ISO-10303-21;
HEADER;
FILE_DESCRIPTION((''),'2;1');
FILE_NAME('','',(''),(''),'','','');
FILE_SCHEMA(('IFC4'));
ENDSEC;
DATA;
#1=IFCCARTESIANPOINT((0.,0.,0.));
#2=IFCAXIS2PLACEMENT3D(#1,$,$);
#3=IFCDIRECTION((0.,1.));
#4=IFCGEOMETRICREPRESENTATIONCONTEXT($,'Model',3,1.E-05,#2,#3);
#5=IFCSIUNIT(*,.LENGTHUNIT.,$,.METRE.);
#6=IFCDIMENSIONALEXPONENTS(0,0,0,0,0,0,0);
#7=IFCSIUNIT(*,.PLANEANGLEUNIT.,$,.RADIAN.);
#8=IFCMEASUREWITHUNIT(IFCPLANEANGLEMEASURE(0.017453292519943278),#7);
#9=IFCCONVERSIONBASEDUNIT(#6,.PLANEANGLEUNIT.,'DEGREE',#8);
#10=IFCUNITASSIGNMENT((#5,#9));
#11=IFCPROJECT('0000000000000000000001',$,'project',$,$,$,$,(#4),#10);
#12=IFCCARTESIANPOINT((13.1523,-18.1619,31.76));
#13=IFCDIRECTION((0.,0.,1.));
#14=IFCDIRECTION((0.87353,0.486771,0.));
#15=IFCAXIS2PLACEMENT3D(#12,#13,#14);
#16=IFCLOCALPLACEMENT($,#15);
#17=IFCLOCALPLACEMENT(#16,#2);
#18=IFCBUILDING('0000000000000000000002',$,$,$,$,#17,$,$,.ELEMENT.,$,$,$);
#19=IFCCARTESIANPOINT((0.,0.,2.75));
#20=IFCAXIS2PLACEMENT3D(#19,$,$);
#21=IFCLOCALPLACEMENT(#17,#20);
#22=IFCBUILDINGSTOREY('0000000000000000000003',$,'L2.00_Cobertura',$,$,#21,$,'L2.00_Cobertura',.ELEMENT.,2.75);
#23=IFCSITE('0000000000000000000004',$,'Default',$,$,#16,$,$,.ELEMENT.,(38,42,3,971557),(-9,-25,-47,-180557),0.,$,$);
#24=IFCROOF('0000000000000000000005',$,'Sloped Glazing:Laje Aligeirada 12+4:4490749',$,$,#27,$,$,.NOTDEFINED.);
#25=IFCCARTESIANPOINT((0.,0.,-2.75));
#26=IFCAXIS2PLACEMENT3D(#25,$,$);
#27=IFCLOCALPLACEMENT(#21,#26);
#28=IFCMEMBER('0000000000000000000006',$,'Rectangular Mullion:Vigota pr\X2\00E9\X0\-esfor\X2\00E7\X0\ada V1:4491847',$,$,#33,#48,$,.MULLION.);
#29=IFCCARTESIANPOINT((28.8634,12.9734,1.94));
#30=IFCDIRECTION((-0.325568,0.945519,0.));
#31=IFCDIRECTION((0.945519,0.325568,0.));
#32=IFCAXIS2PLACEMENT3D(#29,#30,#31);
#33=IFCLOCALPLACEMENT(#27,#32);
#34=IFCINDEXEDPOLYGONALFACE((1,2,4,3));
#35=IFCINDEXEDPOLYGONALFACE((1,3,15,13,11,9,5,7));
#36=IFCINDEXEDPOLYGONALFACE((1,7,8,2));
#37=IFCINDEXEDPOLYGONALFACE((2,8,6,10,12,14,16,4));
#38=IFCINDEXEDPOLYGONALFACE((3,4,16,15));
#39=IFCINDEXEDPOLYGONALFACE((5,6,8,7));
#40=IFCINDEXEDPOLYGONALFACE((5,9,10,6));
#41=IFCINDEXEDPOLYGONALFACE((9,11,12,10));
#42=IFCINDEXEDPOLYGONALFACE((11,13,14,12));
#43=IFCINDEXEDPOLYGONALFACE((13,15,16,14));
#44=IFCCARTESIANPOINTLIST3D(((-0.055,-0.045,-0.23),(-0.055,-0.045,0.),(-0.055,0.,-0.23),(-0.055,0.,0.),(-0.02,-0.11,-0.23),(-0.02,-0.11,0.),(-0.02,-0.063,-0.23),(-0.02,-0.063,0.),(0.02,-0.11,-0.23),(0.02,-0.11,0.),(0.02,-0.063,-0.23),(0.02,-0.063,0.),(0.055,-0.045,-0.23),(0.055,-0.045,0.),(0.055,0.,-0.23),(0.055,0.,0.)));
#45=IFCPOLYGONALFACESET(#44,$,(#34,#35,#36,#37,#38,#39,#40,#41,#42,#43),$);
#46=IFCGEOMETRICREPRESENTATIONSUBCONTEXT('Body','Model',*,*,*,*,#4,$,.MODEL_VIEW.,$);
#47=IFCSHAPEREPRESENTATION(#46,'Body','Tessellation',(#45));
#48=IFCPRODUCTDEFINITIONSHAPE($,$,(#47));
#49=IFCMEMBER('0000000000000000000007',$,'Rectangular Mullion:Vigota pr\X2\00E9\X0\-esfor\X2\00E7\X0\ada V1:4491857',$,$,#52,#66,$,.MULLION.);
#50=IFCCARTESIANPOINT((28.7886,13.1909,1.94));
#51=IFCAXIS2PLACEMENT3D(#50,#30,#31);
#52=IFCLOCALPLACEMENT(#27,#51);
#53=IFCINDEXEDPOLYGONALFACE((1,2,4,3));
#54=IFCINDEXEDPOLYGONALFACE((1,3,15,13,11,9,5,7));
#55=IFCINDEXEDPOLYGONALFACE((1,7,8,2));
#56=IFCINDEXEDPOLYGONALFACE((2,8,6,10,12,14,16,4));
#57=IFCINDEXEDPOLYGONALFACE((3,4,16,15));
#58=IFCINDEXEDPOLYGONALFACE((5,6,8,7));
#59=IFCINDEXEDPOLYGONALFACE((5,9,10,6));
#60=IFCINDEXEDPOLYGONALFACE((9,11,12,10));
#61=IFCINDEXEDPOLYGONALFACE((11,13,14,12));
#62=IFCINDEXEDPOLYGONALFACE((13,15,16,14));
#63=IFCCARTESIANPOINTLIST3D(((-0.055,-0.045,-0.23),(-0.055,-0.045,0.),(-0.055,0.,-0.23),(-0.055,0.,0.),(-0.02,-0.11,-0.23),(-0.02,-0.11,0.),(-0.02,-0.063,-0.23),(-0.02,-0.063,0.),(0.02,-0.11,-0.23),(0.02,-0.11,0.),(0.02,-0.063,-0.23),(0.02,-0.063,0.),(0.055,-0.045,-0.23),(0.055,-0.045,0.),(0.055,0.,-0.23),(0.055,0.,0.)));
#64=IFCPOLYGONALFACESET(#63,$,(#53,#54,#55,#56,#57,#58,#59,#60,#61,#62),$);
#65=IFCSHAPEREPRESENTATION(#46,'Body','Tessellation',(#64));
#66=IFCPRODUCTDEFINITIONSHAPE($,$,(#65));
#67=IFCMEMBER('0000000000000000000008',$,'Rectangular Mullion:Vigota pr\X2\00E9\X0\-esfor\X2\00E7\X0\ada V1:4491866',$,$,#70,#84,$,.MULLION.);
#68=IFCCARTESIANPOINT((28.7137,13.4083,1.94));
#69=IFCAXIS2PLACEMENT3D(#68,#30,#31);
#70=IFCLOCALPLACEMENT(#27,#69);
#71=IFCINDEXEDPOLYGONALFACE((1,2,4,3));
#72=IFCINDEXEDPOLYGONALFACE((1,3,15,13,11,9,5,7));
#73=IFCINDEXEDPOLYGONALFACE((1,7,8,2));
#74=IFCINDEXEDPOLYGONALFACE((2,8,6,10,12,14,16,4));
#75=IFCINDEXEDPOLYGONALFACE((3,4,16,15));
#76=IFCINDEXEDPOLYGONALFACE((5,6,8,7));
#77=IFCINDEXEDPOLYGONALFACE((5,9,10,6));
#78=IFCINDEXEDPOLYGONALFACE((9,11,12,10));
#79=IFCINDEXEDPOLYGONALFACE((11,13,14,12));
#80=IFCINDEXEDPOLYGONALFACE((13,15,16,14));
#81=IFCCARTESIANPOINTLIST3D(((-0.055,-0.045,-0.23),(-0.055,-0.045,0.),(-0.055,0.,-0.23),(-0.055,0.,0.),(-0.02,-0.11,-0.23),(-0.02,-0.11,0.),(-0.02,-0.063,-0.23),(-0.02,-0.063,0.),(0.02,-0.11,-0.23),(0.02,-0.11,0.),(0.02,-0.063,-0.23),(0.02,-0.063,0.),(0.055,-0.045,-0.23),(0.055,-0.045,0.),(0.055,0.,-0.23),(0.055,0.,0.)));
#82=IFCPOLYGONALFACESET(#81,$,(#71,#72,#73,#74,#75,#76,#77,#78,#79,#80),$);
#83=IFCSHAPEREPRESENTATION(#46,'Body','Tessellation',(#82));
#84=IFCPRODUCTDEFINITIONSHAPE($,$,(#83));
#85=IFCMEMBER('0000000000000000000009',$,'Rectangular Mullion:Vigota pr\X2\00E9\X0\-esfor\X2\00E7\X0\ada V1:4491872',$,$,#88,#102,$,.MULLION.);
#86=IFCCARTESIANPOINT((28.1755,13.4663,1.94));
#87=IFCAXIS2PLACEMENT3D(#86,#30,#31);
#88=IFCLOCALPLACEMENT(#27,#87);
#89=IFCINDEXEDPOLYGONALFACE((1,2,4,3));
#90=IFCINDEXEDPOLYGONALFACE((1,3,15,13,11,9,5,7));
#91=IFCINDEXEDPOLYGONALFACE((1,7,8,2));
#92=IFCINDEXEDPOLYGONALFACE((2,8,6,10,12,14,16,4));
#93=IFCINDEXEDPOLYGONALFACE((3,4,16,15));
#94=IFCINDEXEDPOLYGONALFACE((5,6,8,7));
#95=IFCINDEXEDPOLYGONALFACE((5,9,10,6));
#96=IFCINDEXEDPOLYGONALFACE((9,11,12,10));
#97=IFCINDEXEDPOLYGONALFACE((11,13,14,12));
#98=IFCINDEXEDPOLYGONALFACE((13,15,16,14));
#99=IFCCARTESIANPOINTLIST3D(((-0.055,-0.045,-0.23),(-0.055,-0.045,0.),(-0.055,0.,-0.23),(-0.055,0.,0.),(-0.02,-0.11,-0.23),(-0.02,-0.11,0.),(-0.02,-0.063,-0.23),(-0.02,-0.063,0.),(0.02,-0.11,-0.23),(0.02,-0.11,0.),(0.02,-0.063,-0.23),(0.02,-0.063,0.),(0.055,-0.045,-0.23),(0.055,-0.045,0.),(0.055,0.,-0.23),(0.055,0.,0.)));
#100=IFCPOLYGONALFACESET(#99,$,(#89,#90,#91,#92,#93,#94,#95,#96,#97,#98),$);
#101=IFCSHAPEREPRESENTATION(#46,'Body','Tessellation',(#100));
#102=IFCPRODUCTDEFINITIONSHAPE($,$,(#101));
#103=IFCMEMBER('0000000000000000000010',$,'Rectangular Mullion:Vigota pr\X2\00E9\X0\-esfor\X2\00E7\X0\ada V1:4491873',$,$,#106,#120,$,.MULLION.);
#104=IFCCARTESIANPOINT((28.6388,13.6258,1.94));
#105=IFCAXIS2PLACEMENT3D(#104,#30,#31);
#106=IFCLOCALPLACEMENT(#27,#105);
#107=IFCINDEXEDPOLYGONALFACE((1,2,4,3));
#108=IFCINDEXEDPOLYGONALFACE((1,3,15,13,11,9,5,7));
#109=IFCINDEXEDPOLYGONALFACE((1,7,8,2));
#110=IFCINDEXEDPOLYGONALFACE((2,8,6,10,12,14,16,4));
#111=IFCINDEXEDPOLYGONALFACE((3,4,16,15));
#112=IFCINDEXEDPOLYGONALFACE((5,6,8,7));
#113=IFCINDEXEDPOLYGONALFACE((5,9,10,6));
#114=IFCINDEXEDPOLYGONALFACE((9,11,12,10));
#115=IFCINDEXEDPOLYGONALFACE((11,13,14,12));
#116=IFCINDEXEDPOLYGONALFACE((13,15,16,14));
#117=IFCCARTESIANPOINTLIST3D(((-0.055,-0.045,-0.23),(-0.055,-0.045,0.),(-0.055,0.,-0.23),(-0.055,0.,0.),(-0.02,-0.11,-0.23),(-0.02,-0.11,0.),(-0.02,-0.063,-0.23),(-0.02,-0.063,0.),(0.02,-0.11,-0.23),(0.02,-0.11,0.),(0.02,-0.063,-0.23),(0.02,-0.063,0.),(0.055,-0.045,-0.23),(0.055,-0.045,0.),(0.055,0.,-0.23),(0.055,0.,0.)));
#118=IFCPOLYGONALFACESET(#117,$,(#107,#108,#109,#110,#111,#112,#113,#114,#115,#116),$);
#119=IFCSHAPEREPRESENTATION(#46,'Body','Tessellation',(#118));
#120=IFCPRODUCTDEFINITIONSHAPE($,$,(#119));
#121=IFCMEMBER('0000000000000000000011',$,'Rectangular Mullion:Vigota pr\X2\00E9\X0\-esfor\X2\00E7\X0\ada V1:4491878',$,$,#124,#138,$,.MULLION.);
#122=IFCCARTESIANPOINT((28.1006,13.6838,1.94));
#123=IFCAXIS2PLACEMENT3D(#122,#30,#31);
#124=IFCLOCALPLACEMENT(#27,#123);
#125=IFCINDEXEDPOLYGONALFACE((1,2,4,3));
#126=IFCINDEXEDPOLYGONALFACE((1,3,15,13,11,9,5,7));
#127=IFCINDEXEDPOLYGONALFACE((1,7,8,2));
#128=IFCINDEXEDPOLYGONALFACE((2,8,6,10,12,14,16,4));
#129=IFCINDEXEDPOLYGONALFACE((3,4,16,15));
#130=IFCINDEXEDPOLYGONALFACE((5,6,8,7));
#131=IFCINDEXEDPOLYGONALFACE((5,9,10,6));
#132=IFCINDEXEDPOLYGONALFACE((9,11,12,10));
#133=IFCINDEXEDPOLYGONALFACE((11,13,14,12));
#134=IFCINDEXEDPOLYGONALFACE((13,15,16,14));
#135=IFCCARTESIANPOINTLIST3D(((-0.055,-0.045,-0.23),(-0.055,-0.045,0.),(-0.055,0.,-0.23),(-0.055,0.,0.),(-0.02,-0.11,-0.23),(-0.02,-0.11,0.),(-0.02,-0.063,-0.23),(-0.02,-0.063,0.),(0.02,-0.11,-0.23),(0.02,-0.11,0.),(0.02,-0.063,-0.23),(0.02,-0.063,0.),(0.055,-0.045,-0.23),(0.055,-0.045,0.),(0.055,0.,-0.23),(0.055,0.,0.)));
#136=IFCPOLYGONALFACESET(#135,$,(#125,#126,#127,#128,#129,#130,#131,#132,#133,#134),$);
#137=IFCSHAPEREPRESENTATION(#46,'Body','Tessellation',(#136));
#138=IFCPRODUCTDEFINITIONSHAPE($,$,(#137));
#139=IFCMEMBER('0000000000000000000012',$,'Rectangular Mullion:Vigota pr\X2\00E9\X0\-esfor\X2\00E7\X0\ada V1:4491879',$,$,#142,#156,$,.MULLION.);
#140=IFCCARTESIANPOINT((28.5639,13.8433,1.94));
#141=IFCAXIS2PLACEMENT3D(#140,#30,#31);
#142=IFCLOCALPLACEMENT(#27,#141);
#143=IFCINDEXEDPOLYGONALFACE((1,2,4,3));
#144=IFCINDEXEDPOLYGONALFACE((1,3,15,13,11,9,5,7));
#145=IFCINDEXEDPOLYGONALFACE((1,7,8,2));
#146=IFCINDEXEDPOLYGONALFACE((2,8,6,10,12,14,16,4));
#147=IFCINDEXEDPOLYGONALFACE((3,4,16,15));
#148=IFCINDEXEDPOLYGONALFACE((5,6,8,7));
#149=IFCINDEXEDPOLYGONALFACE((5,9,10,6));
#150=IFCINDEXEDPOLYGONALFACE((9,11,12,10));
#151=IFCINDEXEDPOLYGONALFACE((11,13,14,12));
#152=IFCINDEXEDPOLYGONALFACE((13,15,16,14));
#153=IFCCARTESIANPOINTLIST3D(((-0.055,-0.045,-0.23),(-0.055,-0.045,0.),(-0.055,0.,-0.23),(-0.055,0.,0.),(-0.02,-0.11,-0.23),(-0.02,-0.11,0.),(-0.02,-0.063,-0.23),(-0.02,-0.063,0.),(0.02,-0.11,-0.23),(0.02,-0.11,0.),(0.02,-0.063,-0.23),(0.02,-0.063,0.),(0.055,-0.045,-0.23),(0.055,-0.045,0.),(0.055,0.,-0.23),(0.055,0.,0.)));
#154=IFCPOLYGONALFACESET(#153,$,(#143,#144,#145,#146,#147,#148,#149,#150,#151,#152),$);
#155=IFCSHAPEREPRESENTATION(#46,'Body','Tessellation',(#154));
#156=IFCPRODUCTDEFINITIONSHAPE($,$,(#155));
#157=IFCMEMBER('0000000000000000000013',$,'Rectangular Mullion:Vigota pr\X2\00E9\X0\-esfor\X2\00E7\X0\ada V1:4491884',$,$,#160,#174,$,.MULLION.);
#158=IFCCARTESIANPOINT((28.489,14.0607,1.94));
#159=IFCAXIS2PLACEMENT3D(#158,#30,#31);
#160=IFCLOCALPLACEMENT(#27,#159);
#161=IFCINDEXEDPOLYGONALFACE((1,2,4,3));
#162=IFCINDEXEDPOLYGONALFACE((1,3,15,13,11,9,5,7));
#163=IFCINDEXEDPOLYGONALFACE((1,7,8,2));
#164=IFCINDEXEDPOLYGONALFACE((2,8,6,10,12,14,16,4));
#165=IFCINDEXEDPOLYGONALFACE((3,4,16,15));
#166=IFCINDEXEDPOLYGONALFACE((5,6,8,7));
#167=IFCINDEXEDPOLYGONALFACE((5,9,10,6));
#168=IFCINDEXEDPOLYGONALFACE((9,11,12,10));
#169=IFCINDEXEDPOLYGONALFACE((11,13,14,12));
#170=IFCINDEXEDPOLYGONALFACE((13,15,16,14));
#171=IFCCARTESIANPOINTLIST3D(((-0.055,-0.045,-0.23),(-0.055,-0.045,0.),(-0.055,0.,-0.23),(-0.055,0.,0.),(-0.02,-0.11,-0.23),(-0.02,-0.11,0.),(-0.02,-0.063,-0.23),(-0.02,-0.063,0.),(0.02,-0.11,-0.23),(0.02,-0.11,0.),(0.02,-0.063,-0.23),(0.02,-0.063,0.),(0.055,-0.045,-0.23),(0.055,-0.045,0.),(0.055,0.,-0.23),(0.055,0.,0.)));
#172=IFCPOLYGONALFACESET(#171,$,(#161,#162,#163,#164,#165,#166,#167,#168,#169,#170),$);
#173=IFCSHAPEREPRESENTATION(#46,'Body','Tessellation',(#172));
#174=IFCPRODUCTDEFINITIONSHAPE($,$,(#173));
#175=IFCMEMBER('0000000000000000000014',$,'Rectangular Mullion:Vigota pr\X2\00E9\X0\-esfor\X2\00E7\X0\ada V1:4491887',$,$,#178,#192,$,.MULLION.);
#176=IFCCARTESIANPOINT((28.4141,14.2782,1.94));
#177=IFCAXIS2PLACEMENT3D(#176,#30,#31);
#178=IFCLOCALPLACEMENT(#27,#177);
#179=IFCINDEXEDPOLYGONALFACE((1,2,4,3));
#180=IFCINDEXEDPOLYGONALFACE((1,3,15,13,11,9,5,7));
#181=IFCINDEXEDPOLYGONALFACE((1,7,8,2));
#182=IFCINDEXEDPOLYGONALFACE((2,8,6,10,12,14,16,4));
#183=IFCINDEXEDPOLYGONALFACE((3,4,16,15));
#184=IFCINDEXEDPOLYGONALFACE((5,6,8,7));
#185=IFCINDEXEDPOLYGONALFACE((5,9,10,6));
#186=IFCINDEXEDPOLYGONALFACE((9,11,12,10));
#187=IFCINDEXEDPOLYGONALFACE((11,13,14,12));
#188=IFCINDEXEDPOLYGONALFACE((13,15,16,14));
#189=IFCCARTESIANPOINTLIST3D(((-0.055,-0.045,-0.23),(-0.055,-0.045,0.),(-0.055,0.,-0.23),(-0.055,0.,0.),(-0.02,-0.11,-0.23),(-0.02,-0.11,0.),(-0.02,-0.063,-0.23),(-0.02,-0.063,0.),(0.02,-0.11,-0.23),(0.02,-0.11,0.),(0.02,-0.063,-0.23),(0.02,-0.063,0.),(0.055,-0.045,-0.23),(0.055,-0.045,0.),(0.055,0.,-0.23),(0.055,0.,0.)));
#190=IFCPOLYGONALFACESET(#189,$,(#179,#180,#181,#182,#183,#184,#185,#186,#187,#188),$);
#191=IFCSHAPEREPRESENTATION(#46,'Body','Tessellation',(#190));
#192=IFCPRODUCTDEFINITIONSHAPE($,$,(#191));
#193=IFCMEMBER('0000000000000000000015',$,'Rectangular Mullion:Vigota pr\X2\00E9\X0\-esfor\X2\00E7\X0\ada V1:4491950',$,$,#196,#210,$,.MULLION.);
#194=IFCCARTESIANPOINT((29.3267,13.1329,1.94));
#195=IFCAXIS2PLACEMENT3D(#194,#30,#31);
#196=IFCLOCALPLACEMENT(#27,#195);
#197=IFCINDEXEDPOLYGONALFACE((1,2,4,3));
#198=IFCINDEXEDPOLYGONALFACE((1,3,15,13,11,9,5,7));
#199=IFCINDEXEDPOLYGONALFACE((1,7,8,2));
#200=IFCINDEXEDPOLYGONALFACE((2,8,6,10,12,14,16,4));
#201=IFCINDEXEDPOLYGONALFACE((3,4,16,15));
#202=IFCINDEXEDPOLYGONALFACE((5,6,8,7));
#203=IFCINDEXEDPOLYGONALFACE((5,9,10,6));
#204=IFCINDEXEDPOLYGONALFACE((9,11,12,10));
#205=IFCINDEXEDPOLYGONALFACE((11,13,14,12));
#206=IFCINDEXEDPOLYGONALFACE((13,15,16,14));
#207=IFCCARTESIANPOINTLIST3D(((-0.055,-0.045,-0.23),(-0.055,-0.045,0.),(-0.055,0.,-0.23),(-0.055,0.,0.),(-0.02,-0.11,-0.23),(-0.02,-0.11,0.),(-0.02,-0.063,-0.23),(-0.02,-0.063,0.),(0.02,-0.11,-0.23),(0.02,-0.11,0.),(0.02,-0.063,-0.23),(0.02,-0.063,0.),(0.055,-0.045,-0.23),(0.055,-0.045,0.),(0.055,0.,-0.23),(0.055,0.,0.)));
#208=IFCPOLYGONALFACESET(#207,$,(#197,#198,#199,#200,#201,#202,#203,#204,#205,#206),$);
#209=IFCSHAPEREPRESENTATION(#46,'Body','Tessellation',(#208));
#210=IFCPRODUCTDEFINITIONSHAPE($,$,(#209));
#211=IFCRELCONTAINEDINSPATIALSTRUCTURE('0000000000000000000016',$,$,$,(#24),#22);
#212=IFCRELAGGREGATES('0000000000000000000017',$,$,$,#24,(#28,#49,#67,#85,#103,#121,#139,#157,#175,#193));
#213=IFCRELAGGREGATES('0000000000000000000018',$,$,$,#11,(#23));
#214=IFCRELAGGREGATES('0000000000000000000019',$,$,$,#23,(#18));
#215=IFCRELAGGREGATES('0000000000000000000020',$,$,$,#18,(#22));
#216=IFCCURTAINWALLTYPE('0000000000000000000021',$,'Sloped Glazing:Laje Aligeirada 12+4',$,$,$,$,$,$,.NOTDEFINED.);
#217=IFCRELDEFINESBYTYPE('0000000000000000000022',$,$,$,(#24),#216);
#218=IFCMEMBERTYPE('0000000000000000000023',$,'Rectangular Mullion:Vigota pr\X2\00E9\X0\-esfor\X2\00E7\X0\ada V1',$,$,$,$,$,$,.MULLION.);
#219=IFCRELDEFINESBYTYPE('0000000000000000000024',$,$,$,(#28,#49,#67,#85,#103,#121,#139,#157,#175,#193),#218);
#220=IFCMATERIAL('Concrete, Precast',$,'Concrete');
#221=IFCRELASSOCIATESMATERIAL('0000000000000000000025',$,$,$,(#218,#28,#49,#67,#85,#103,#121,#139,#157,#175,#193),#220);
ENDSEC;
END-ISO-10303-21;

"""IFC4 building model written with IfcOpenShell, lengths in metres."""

from ifc_helpers import new_model, entity, si_unit, converted_unit, direction, frame, origin, place, context, subcontext, project, spatial, indexed_curve, outline, extrude, source, transform, mapped, material, type_object, type_shapes, element, aggregate, save


model = new_model("IFC4")

# Units and contexts
model_context = context("Model", 3, precision=1e-05, world=origin(), true_north=direction((0.0, 1.0)))
body_context = subcontext(model_context, "Body", "Model", "MODEL_VIEW")
ifc_project = project(units=[si_unit("LENGTHUNIT", "METRE"), converted_unit("PLANEANGLEUNIT", "DEGREE", entity("IfcPlaneAngleMeasure", 0.017453292519943278), si_unit("PLANEANGLEUNIT", "RADIAN"), dimensions=[0, 0, 0, 0, 0, 0, 0])], contexts=[model_context])

# Site, building, storey
site_placement = place(None, frame((13.1523, -18.1619, 31.76), z_axis=(0.0, 0.0, 1.0), x_axis=(0.87353, 0.486771, 0.0)))
site = spatial("IfcSite", under=ifc_project, at=site_placement, Name="Default", CompositionType="ELEMENT", RefLatitude=(38, 42, 3, 971557), RefLongitude=(-9, -25, -47, -180557), RefElevation=0.0)
building_placement = place(site_placement, origin())
building = spatial("IfcBuilding", under=site, at=building_placement, CompositionType="ELEMENT")
storey_placement = place(building_placement, frame((0.0, 0.0, 2.75)))
storey = spatial("IfcBuildingStorey", under=building, at=storey_placement, Name="L2.00_Cobertura", LongName="L2.00_Cobertura", CompositionType="ELEMENT", Elevation=2.75)

# Roof, members
curtain_wall_type = type_object("IfcCurtainWallType", Name="Sloped Glazing:Laje Aligeirada 12+4", PredefinedType="NOTDEFINED")
roof_placement = place(storey_placement, frame((0.0, 0.0, -2.75)))
roof = element("IfcRoof", 1, at=roof_placement, inside=storey, type_object=curtain_wall_type, Name="Sloped Glazing:Laje Aligeirada 12+4:4490749", PredefinedType="NOTDEFINED")
ifc_material_1 = material(Name="Concrete, Precast", Category="Concrete")
member_type_1 = type_object("IfcMemberType", Name="Rectangular Mullion:Vigota pré-esforçada V1", PredefinedType="MULLION", material=ifc_material_1)
shared_shape_1 = source(origin(), body_context, "Body", "SweptSolid", [
    extrude(outline(indexed_curve([(-0.055, -0.0545), (0.055, -0.0545), (0.055, -0.0095), (0.02, 0.0085), (0.02, 0.0555), (-0.02, 0.0555), (-0.02, 0.0085), (-0.055, -0.0095), (-0.055, -0.0545)], self_intersect=False)), frame((0.0, -0.0545, -0.23), z_axis=(0.0, 0.0, 1.0), x_axis=(-1.0, 0.0, 0.0)), (0.0, 0.0, 1.0), 0.23),
])
type_shapes(member_type_1, [shared_shape_1])
member_1_placement = place(roof_placement, frame((28.8634, 12.9734, 1.94), z_axis=(-0.325568, 0.945519, 0.0), x_axis=(0.945519, 0.325568, 0.0)))
member_1 = element("IfcMember", 2, at=member_1_placement, type_object=member_type_1, material=ifc_material_1, Name="Rectangular Mullion:Vigota pré-esforçada V1:4491847", PredefinedType="MULLION", context=body_context, shape_type="MappedRepresentation", body=[
    mapped(shared_shape_1, transform((0.0, 0.0, 0.0), scale=1.0)),
])
member_2_placement = place(roof_placement, frame((28.7886, 13.1909, 1.94), z_axis=(-0.325568, 0.945519, 0.0), x_axis=(0.945519, 0.325568, 0.0)))
member_2 = element("IfcMember", 3, at=member_2_placement, type_object=member_type_1, material=ifc_material_1, Name="Rectangular Mullion:Vigota pré-esforçada V1:4491857", PredefinedType="MULLION", context=body_context, shape_type="MappedRepresentation", body=[
    mapped(shared_shape_1, transform((0.0, 0.0, 0.0), scale=1.0)),
])
member_3_placement = place(roof_placement, frame((28.7137, 13.4083, 1.94), z_axis=(-0.325568, 0.945519, 0.0), x_axis=(0.945519, 0.325568, 0.0)))
member_3 = element("IfcMember", 4, at=member_3_placement, type_object=member_type_1, material=ifc_material_1, Name="Rectangular Mullion:Vigota pré-esforçada V1:4491866", PredefinedType="MULLION", context=body_context, shape_type="MappedRepresentation", body=[
    mapped(shared_shape_1, transform((0.0, 0.0, 0.0), scale=1.0)),
])
member_4_placement = place(roof_placement, frame((28.1755, 13.4663, 1.94), z_axis=(-0.325568, 0.945519, 0.0), x_axis=(0.945519, 0.325568, 0.0)))
member_4 = element("IfcMember", 5, at=member_4_placement, type_object=member_type_1, material=ifc_material_1, Name="Rectangular Mullion:Vigota pré-esforçada V1:4491872", PredefinedType="MULLION", context=body_context, shape_type="MappedRepresentation", body=[
    mapped(shared_shape_1, transform((0.0, 0.0, 0.0), scale=1.0)),
])
member_5_placement = place(roof_placement, frame((28.6388, 13.6258, 1.94), z_axis=(-0.325568, 0.945519, 0.0), x_axis=(0.945519, 0.325568, 0.0)))
member_5 = element("IfcMember", 6, at=member_5_placement, type_object=member_type_1, material=ifc_material_1, Name="Rectangular Mullion:Vigota pré-esforçada V1:4491873", PredefinedType="MULLION", context=body_context, shape_type="MappedRepresentation", body=[
    mapped(shared_shape_1, transform((0.0, 0.0, 0.0), scale=1.0)),
])
member_6_placement = place(roof_placement, frame((28.1006, 13.6838, 1.94), z_axis=(-0.325568, 0.945519, 0.0), x_axis=(0.945519, 0.325568, 0.0)))
member_6 = element("IfcMember", 7, at=member_6_placement, type_object=member_type_1, material=ifc_material_1, Name="Rectangular Mullion:Vigota pré-esforçada V1:4491878", PredefinedType="MULLION", context=body_context, shape_type="MappedRepresentation", body=[
    mapped(shared_shape_1, transform((0.0, 0.0, 0.0), scale=1.0)),
])
member_7_placement = place(roof_placement, frame((28.5639, 13.8433, 1.94), z_axis=(-0.325568, 0.945519, 0.0), x_axis=(0.945519, 0.325568, 0.0)))
member_7 = element("IfcMember", 8, at=member_7_placement, type_object=member_type_1, material=ifc_material_1, Name="Rectangular Mullion:Vigota pré-esforçada V1:4491879", PredefinedType="MULLION", context=body_context, shape_type="MappedRepresentation", body=[
    mapped(shared_shape_1, transform((0.0, 0.0, 0.0), scale=1.0)),
])
member_8_placement = place(roof_placement, frame((28.489, 14.0607, 1.94), z_axis=(-0.325568, 0.945519, 0.0), x_axis=(0.945519, 0.325568, 0.0)))
member_8 = element("IfcMember", 9, at=member_8_placement, type_object=member_type_1, material=ifc_material_1, Name="Rectangular Mullion:Vigota pré-esforçada V1:4491884", PredefinedType="MULLION", context=body_context, shape_type="MappedRepresentation", body=[
    mapped(shared_shape_1, transform((0.0, 0.0, 0.0), scale=1.0)),
])
member_9_placement = place(roof_placement, frame((28.4141, 14.2782, 1.94), z_axis=(-0.325568, 0.945519, 0.0), x_axis=(0.945519, 0.325568, 0.0)))
member_9 = element("IfcMember", 10, at=member_9_placement, type_object=member_type_1, material=ifc_material_1, Name="Rectangular Mullion:Vigota pré-esforçada V1:4491887", PredefinedType="MULLION", context=body_context, shape_type="MappedRepresentation", body=[
    mapped(shared_shape_1, transform((0.0, 0.0, 0.0), scale=1.0)),
])
member_10_placement = place(roof_placement, frame((29.3267, 13.1329, 1.94), z_axis=(-0.325568, 0.945519, 0.0), x_axis=(0.945519, 0.325568, 0.0)))
member_10 = element("IfcMember", 11, at=member_10_placement, type_object=member_type_1, material=ifc_material_1, Name="Rectangular Mullion:Vigota pré-esforçada V1:4491950", PredefinedType="MULLION", context=body_context, shape_type="MappedRepresentation", body=[
    mapped(shared_shape_1, transform((0.0, 0.0, 0.0), scale=1.0)),
])
aggregate(roof, [member_1, member_2, member_3, member_4, member_5, member_6, member_7, member_8, member_9, member_10])

save(model, "model.ifc")
